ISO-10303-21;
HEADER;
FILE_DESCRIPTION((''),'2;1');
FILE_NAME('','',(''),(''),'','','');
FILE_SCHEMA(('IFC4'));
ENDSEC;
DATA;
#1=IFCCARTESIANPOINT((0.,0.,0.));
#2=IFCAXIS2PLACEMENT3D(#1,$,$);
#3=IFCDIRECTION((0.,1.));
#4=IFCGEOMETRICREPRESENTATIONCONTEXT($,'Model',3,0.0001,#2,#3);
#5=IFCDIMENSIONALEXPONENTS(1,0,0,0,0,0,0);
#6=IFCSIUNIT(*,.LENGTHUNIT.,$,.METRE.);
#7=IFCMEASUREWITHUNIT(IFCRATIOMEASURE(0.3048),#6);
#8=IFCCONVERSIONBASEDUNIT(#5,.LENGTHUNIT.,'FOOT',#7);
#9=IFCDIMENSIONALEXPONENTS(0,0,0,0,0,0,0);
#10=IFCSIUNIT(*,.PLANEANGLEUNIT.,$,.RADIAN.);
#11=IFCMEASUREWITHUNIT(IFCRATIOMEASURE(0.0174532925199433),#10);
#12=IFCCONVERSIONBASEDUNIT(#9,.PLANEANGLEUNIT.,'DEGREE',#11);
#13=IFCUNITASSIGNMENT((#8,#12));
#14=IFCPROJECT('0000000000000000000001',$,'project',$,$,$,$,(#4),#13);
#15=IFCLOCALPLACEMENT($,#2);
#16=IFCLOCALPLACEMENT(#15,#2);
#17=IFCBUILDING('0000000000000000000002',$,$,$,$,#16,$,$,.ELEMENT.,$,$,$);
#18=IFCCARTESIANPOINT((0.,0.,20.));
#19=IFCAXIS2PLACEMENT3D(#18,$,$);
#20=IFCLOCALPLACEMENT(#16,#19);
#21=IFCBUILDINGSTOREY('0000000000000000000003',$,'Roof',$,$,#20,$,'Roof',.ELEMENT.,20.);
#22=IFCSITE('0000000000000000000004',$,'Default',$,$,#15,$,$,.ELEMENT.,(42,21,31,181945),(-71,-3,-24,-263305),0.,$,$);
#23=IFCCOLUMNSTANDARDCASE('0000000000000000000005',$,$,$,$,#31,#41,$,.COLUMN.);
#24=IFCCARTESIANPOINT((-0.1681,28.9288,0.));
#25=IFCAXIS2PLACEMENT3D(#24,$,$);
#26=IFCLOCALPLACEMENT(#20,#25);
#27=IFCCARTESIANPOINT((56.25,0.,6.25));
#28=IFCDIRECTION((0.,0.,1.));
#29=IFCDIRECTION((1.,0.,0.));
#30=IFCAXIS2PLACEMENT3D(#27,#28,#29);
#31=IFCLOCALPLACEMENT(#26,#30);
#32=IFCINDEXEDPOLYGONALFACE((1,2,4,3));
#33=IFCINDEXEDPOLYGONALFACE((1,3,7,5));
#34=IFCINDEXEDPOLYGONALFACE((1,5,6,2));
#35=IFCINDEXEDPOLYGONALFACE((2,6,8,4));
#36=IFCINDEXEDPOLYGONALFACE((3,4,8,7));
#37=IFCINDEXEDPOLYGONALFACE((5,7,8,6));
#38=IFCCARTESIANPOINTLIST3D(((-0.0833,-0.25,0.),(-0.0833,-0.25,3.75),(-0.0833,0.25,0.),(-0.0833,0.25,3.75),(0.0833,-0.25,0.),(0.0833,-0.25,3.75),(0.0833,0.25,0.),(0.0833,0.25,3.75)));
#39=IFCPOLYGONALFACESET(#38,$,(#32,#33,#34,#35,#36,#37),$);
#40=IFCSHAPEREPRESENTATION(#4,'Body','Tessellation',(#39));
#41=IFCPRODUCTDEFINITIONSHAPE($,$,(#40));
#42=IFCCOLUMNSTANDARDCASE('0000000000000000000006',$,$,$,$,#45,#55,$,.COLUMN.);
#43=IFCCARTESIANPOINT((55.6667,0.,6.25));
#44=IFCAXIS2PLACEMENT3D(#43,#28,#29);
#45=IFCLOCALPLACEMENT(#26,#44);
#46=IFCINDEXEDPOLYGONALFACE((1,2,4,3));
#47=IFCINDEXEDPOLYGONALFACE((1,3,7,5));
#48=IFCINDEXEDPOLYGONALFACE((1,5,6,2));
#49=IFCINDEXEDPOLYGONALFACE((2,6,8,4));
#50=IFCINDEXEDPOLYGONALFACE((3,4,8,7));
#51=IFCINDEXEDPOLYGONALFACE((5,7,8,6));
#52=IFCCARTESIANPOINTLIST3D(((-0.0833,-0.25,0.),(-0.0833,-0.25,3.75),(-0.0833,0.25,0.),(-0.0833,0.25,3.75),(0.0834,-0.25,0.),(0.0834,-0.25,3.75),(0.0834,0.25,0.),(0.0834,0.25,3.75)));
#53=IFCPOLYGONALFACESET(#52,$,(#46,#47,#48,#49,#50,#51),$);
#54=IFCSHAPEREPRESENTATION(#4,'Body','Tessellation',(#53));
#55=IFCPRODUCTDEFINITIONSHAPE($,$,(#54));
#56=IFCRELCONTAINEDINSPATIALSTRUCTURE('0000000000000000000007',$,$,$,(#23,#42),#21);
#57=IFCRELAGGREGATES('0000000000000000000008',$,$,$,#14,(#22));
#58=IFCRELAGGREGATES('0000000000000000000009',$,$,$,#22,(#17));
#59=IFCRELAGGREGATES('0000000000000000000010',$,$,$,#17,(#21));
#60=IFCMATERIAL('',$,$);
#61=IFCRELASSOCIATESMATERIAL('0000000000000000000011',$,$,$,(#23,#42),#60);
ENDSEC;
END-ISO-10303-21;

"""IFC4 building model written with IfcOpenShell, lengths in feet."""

from ifc_helpers import new_model, entity, si_unit, converted_unit, direction, frame, origin, place, context, project, spatial, rectangle, extrude, material, element, save


model = new_model("IFC4")

# Units and contexts
model_context = context("Model", 3, precision=0.0001, world=origin(), true_north=direction((0.0, 1.0)))
ifc_project = project(units=[converted_unit("LENGTHUNIT", "FOOT", entity("IfcRatioMeasure", 0.3048), si_unit("LENGTHUNIT", "METRE"), dimensions=[1, 0, 0, 0, 0, 0, 0]), converted_unit("PLANEANGLEUNIT", "DEGREE", entity("IfcRatioMeasure", 0.0174532925199433), si_unit("PLANEANGLEUNIT", "RADIAN"), dimensions=[0, 0, 0, 0, 0, 0, 0])], contexts=[model_context])

# Site, building, storey
site_placement = place(None, origin())
site = spatial("IfcSite", under=ifc_project, at=site_placement, Name="Default", CompositionType="ELEMENT", RefLatitude=(42, 21, 31, 181945), RefLongitude=(-71, -3, -24, -263305), RefElevation=0.0)
building_placement = place(site_placement, origin())
building = spatial("IfcBuilding", under=site, at=building_placement, CompositionType="ELEMENT")
storey_placement = place(building_placement, frame((0.0, 0.0, 20.0)))
storey = spatial("IfcBuildingStorey", under=building, at=storey_placement, Name="Roof", LongName="Roof", CompositionType="ELEMENT", Elevation=20.0)

# Columns
ifc_material = material(Name="")
placement = place(storey_placement, frame((-0.1681, 28.9288, 0.0)))
for number, where, z_axis, x_axis in (
    (1, (56.25, 0.0, 6.25), (0.0, 0.0, 1.0), (1.0, 0.0, 0.0)),
    (2, (55.6667, 0.0, 6.25), (0.0, 0.0, 1.0), (1.0, 0.0, 0.0)),
):
    element("IfcColumnStandardCase", number, at=place(placement, frame(where, z_axis=z_axis, x_axis=x_axis)), inside=storey, material=ifc_material, PredefinedType="COLUMN", context=model_context, shape_type="SweptSolid", body=[
        extrude(rectangle(XDim=0.1667, YDim=0.5), origin(), (0.0, 0.0, 1.0), 3.75),
    ])

save(model, "model.ifc")
